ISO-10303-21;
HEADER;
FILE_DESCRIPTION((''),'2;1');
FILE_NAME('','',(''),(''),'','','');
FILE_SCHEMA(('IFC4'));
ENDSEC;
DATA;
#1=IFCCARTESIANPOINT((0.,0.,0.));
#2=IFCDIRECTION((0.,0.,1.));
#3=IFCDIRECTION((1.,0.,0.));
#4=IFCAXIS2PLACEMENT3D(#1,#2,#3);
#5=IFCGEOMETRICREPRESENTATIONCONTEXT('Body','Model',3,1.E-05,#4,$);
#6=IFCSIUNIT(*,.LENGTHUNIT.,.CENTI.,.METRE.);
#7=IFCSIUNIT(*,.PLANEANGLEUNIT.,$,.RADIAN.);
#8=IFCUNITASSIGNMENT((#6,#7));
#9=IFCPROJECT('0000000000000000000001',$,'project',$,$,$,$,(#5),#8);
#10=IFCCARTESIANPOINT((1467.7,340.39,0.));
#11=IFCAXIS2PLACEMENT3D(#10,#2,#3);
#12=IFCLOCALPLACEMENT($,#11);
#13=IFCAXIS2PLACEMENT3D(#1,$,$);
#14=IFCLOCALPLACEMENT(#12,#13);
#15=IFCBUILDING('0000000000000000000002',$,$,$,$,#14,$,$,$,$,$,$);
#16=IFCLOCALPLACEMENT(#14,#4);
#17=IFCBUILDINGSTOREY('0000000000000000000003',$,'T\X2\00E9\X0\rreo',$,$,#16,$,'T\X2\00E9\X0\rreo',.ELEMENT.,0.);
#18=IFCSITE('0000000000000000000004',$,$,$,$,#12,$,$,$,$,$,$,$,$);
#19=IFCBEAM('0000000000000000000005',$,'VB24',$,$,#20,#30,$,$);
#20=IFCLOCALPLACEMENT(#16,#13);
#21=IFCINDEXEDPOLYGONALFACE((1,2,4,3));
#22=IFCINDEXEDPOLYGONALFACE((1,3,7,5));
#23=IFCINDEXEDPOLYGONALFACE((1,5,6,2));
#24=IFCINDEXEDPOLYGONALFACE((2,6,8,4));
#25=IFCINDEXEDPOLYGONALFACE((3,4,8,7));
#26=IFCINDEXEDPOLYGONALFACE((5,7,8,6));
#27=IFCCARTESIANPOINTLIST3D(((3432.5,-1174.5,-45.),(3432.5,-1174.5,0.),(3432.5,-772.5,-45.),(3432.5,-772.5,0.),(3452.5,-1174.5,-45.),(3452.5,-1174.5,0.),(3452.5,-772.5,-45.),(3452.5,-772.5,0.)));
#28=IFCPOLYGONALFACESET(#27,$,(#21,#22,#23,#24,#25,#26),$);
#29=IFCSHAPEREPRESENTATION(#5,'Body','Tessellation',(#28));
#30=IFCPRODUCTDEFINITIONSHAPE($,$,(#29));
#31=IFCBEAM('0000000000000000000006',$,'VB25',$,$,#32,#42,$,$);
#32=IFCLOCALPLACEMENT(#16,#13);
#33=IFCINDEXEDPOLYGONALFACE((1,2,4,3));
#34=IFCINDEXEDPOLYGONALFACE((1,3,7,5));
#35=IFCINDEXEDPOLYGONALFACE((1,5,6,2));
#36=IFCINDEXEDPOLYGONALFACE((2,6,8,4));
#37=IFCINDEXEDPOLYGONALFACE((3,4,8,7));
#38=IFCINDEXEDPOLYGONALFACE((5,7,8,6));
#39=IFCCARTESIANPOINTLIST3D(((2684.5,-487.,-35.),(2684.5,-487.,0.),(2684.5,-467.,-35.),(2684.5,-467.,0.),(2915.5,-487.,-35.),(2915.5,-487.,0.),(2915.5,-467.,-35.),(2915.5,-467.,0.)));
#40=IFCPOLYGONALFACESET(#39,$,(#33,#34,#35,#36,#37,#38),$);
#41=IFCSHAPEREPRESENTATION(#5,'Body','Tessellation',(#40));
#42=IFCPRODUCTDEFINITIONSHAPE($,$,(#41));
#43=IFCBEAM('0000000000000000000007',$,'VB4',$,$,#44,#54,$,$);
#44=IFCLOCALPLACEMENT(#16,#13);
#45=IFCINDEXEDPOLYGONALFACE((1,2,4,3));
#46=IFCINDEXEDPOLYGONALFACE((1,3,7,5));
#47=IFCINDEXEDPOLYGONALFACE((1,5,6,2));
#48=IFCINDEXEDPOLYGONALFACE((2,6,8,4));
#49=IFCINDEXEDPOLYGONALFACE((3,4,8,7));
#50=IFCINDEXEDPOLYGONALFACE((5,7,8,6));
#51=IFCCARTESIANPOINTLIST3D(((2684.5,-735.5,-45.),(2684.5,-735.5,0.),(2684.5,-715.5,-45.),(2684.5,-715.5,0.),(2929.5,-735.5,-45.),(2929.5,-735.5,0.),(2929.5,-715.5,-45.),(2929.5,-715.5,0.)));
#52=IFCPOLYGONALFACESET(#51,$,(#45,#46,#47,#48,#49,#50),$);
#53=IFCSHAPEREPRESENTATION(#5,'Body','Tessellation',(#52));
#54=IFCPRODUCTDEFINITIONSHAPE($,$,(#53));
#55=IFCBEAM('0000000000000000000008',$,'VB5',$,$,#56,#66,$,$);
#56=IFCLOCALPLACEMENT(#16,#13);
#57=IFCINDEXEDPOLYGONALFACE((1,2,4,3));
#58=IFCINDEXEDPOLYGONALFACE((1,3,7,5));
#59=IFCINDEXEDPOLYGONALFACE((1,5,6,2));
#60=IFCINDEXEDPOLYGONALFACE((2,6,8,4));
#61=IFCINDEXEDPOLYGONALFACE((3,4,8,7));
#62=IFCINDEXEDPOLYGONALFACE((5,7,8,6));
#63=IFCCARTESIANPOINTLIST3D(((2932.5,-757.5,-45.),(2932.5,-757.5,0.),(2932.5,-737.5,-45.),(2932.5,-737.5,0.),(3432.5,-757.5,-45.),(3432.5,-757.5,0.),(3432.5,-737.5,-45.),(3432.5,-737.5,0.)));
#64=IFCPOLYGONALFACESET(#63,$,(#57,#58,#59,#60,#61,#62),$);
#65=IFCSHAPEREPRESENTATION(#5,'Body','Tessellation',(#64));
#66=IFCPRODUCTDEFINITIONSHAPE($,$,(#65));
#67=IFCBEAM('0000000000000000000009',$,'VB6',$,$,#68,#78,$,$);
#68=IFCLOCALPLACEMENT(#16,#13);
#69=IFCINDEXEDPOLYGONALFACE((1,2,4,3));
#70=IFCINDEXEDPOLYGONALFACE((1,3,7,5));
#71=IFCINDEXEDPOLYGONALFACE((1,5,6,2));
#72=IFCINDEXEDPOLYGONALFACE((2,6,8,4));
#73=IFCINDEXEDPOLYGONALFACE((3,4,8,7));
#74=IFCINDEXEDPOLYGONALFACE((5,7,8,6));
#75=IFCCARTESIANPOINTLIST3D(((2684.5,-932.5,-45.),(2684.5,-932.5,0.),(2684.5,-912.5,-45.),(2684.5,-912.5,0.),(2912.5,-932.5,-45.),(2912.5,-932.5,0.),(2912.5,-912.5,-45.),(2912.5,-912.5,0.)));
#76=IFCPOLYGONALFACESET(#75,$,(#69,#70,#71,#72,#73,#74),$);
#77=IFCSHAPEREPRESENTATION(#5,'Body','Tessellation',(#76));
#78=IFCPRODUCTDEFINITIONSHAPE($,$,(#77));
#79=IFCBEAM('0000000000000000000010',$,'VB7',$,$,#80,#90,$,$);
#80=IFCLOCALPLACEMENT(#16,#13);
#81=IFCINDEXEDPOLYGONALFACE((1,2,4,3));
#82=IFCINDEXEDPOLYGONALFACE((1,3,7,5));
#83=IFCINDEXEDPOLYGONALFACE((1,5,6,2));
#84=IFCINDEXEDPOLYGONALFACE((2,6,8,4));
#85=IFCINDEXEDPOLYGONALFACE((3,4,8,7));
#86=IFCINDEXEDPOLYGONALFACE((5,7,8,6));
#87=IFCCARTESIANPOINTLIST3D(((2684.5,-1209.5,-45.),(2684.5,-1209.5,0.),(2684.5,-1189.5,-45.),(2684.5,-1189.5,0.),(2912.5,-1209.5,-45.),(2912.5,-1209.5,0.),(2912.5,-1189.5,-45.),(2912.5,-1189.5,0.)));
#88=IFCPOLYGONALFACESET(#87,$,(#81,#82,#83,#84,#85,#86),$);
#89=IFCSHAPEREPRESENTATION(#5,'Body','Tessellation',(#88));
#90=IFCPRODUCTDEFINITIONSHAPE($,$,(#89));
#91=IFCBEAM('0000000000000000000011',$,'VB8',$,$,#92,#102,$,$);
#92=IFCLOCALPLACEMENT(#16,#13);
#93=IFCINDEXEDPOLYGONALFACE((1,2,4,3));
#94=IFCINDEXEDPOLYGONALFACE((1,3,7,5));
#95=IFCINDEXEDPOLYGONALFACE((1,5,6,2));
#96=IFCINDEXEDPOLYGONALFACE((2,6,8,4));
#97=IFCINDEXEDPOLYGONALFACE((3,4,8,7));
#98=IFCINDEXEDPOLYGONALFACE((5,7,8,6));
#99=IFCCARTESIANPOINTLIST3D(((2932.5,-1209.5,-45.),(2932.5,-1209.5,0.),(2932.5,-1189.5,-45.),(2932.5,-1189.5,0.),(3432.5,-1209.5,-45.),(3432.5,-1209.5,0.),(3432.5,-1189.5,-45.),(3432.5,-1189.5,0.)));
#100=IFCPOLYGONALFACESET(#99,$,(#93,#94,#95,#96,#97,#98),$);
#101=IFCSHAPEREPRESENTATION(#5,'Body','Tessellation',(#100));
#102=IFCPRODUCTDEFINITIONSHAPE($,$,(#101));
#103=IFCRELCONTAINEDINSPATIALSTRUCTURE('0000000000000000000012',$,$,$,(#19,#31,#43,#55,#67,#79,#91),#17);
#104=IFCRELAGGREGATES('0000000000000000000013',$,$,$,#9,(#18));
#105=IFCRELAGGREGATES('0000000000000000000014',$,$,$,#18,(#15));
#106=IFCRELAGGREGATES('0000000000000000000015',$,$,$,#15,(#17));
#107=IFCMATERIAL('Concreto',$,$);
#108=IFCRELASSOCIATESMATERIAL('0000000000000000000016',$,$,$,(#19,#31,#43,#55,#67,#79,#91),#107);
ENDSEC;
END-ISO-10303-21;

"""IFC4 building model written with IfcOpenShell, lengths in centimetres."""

from ifc_helpers import new_model, si_unit, frame, origin, origin_with_axes, origin_2d_with_axis, place, context, project, spatial, rectangle, extrude, material, element, save


model = new_model("IFC4")

# Units and contexts
model_context = context("Model", 3, precision=1e-05, world=origin_with_axes(), identifier="Body")
ifc_project = project(units=[si_unit("LENGTHUNIT", "METRE", prefix="CENTI"), si_unit("PLANEANGLEUNIT", "RADIAN")], contexts=[model_context])

# Site, building, storey
site_placement = place(None, frame((1467.7, 340.39, 0.0), z_axis=(0.0, 0.0, 1.0), x_axis=(1.0, 0.0, 0.0)))
site = spatial("IfcSite", under=ifc_project, at=site_placement)
building_placement = place(site_placement, origin())
building = spatial("IfcBuilding", under=site, at=building_placement)
storey_placement = place(building_placement, origin_with_axes())
storey = spatial("IfcBuildingStorey", under=building, at=storey_placement, Name="Térreo", LongName="Térreo", CompositionType="ELEMENT", Elevation=0.0)

# Shared definitions
ifc_material = material(Name="Concreto")

# Beams
beam_1_placement = place(storey_placement, frame((3442.5, -973.5, 0.0), z_axis=(0.0, 0.0, 1.0), x_axis=(1.0, 0.0, 0.0)))
element("IfcBeam", 1, at=beam_1_placement, inside=storey, material=ifc_material, Name="VB24", context=model_context, shape_type="SolidModel", body=[
    extrude(rectangle(XDim=20.0, YDim=45.0, at=origin_2d_with_axis()), frame((0.0, -201.0, -22.5), z_axis=(0.0, 1.0, 0.0), x_axis=(1.0, 0.0, 0.0)), (0.0, 0.0, 1.0), 402.0),
])
beam_2_placement = place(storey_placement, frame((2800.0, -477.0, 0.0), z_axis=(0.0, 0.0, 1.0), x_axis=(1.0, 0.0, 0.0)))
element("IfcBeam", 2, at=beam_2_placement, inside=storey, material=ifc_material, Name="VB25", context=model_context, shape_type="SolidModel", body=[
    extrude(rectangle(XDim=20.0, YDim=35.0, at=origin_2d_with_axis()), frame((-115.5, 0.0, -17.5), z_axis=(1.0, 0.0, 0.0), x_axis=(0.0, 1.0, 0.0)), (0.0, 0.0, 1.0), 231.0),
])
beam_3_placement = place(storey_placement, frame((2807.0, -725.5, 0.0), z_axis=(0.0, 0.0, 1.0), x_axis=(1.0, 0.0, 0.0)))
element("IfcBeam", 3, at=beam_3_placement, inside=storey, material=ifc_material, Name="VB4", context=model_context, shape_type="SolidModel", body=[
    extrude(rectangle(XDim=20.0, YDim=45.0, at=origin_2d_with_axis()), frame((-122.5, 0.0, -22.5), z_axis=(1.0, 0.0, 0.0), x_axis=(0.0, 1.0, 0.0)), (0.0, 0.0, 1.0), 245.0),
])
beam_4_placement = place(storey_placement, frame((3182.5, -747.5, 0.0), z_axis=(0.0, 0.0, 1.0), x_axis=(1.0, 0.0, 0.0)))
element("IfcBeam", 4, at=beam_4_placement, inside=storey, material=ifc_material, Name="VB5", context=model_context, shape_type="SolidModel", body=[
    extrude(rectangle(XDim=20.0, YDim=45.0, at=origin_2d_with_axis()), frame((-250.0, 0.0, -22.5), z_axis=(1.0, 0.0, 0.0), x_axis=(0.0, 1.0, 0.0)), (0.0, 0.0, 1.0), 500.0),
])
for number, where, z_axis, x_axis, name in (
    (5, (2798.5, -922.5, 0.0), (0.0, 0.0, 1.0), (1.0, 0.0, 0.0), "VB6"),
    (6, (2798.5, -1199.5, 0.0), (0.0, 0.0, 1.0), (1.0, 0.0, 0.0), "VB7"),
):
    element("IfcBeam", number, at=place(storey_placement, frame(where, z_axis=z_axis, x_axis=x_axis)), inside=storey, material=ifc_material, Name=name, context=model_context, shape_type="SolidModel", body=[
        extrude(rectangle(XDim=20.0, YDim=45.0, at=origin_2d_with_axis()), frame((-114.0, 0.0, -22.5), z_axis=(1.0, 0.0, 0.0), x_axis=(0.0, 1.0, 0.0)), (0.0, 0.0, 1.0), 228.0),
    ])
beam_5_placement = place(storey_placement, frame((3182.5, -1199.5, 0.0), z_axis=(0.0, 0.0, 1.0), x_axis=(1.0, 0.0, 0.0)))
element("IfcBeam", 7, at=beam_5_placement, inside=storey, material=ifc_material, Name="VB8", context=model_context, shape_type="SolidModel", body=[
    extrude(rectangle(XDim=20.0, YDim=45.0, at=origin_2d_with_axis()), frame((-250.0, 0.0, -22.5), z_axis=(1.0, 0.0, 0.0), x_axis=(0.0, 1.0, 0.0)), (0.0, 0.0, 1.0), 500.0),
])

save(model, "model.ifc")
